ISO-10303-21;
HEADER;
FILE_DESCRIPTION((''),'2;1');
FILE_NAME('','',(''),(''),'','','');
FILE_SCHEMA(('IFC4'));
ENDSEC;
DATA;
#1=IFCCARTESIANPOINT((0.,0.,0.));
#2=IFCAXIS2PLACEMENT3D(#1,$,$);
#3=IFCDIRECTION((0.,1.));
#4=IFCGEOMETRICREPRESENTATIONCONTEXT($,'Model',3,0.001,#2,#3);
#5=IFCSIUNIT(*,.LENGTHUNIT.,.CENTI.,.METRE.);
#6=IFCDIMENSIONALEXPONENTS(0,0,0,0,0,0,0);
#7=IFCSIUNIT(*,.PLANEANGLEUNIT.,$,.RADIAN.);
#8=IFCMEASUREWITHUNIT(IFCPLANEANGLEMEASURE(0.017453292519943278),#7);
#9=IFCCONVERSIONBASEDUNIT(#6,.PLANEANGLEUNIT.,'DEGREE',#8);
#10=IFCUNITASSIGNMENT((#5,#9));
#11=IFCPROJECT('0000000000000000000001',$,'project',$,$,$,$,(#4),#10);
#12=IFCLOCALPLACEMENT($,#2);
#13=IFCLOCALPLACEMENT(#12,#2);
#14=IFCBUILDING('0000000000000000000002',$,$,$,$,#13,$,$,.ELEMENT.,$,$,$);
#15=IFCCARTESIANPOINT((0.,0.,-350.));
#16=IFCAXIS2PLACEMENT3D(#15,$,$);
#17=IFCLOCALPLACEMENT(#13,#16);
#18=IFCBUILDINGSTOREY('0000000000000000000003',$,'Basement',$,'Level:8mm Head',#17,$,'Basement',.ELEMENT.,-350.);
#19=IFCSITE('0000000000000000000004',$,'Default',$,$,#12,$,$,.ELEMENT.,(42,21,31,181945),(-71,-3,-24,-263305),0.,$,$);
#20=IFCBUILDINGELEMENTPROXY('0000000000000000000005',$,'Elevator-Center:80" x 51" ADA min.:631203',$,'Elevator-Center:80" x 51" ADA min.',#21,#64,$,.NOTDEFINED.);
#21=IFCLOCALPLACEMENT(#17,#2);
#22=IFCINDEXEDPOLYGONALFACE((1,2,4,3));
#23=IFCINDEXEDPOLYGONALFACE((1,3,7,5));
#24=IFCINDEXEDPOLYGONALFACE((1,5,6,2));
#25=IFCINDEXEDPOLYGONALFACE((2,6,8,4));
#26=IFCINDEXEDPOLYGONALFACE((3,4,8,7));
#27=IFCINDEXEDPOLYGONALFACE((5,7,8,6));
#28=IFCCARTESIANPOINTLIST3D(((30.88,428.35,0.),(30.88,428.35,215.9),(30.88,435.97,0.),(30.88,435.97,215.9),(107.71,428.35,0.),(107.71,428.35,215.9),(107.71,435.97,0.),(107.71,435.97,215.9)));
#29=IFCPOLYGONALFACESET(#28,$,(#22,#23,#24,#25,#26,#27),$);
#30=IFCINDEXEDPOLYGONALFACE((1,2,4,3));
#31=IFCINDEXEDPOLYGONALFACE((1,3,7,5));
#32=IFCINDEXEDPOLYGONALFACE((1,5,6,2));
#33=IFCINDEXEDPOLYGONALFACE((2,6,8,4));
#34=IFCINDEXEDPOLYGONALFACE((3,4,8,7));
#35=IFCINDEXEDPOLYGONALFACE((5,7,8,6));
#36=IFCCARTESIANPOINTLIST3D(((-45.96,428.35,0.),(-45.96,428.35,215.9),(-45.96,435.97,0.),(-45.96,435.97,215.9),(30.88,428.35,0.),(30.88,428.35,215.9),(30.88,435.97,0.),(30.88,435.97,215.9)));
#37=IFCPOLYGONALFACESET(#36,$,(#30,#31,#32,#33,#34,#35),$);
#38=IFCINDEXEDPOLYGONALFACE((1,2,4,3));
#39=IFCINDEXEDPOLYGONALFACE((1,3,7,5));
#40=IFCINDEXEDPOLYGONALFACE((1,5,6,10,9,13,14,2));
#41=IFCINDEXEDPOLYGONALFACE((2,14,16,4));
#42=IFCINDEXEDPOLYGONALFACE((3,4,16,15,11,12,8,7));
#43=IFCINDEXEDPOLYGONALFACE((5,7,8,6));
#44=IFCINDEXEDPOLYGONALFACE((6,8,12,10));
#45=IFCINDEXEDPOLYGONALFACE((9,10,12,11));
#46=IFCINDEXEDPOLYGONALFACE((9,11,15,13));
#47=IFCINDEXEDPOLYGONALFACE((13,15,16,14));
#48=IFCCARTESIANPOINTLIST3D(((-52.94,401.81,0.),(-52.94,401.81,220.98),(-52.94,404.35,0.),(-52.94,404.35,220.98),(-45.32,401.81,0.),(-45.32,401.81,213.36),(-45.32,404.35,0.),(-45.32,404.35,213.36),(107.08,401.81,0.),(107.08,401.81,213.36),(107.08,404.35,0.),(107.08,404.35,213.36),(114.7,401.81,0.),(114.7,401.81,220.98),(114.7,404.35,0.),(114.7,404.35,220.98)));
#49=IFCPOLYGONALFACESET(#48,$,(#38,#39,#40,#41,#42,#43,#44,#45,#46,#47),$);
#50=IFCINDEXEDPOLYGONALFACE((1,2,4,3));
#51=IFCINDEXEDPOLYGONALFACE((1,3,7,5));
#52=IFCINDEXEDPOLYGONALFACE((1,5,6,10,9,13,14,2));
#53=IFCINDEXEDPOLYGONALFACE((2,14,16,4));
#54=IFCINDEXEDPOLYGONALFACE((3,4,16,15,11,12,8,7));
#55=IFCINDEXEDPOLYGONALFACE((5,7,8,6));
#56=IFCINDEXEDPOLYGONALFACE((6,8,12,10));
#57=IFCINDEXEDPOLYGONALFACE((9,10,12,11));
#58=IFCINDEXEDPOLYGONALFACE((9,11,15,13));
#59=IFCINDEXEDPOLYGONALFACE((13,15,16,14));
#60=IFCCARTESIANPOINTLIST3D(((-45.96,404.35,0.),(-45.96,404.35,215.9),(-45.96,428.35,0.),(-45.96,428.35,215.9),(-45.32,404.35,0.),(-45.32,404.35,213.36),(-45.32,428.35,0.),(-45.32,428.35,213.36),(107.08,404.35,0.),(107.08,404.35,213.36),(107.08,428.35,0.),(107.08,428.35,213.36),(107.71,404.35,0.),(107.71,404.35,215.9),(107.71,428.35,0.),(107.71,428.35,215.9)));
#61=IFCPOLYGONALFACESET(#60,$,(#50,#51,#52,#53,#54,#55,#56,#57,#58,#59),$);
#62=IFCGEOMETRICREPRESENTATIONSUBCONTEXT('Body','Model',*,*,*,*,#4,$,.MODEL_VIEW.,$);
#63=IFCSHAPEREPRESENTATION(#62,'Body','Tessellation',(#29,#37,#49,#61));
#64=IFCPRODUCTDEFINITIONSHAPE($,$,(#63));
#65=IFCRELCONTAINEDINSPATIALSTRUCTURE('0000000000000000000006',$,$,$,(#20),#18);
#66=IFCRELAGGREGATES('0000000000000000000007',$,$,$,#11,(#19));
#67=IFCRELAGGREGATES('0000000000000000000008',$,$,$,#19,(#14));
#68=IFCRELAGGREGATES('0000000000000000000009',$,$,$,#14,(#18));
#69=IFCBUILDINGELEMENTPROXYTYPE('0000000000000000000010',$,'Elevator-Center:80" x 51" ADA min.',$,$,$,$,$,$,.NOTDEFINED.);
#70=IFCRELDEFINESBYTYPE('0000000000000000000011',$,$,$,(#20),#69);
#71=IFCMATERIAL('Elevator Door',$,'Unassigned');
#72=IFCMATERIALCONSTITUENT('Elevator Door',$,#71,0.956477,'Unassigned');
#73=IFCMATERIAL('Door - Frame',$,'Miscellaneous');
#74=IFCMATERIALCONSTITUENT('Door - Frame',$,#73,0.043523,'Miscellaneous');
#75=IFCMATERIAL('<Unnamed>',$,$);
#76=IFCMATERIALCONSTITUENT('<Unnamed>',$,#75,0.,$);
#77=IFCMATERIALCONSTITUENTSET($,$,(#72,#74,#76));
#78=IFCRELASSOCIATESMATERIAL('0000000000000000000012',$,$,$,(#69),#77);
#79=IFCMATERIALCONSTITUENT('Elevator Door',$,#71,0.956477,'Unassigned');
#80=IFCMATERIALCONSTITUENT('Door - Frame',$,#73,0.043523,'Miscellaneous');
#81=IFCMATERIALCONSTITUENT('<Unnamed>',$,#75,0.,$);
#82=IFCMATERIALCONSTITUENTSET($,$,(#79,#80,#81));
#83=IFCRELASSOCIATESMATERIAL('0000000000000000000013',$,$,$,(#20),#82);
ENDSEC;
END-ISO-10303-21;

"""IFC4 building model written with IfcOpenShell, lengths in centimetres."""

from ifc_helpers import new_model, entity, si_unit, converted_unit, direction, frame, origin, place, context, subcontext, project, spatial, indexed_curve, outline, extrude, source, transform, mapped, material, constituent, constituent_set, type_object, type_shapes, element, save


model = new_model("IFC4")

# Units and contexts
model_context = context("Model", 3, precision=0.001, world=origin(), true_north=direction((0.0, 1.0)))
body_context = subcontext(model_context, "Body", "Model", "MODEL_VIEW")
ifc_project = project(units=[si_unit("LENGTHUNIT", "METRE", prefix="CENTI"), converted_unit("PLANEANGLEUNIT", "DEGREE", entity("IfcPlaneAngleMeasure", 0.017453292519943278), si_unit("PLANEANGLEUNIT", "RADIAN"), dimensions=[0, 0, 0, 0, 0, 0, 0])], contexts=[model_context])

# Site, building, storey
site_placement = place(None, origin())
site = spatial("IfcSite", under=ifc_project, at=site_placement, Name="Default", CompositionType="ELEMENT", RefLatitude=(42, 21, 31, 181945), RefLongitude=(-71, -3, -24, -263305), RefElevation=0.0)
building_placement = place(site_placement, origin())
building = spatial("IfcBuilding", under=site, at=building_placement, CompositionType="ELEMENT")
storey_placement = place(building_placement, frame((0.0, 0.0, -350.0)))
storey = spatial("IfcBuildingStorey", under=building, at=storey_placement, Name="Basement", ObjectType="Level:8mm Head", LongName="Basement", CompositionType="ELEMENT", Elevation=-350.0)

# Shared definitions
ifc_material_1 = material(Name="Door - Frame", Category="Miscellaneous")

# Building element proxy
ifc_material_2 = material(Name="Elevator Door", Category="Unassigned")
ifc_constituent_1 = constituent(ifc_material_2, Name="Elevator Door", Category="Unassigned", fraction=0.956477)
ifc_constituent_2 = constituent(ifc_material_1, Name="Door - Frame", Category="Miscellaneous", fraction=0.043523)
ifc_material_3 = material(Name="<Unnamed>")
ifc_constituent_3 = constituent(ifc_material_3, Name="<Unnamed>", fraction=0.0)
ifc_constituent_set_1 = constituent_set(constituents=[ifc_constituent_1, ifc_constituent_2, ifc_constituent_3])
ifc_constituent_4 = constituent(ifc_material_2, Name="Elevator Door", Category="Unassigned", fraction=0.956477)
ifc_constituent_5 = constituent(ifc_material_1, Name="Door - Frame", Category="Miscellaneous", fraction=0.043523)
ifc_constituent_6 = constituent(ifc_material_3, Name="<Unnamed>", fraction=0.0)
ifc_constituent_set_2 = constituent_set(constituents=[ifc_constituent_4, ifc_constituent_5, ifc_constituent_6])
building_element_proxy_type = type_object("IfcBuildingElementProxyType", Name="Elevator-Center:80\" x 51\" ADA min.", PredefinedType="NOTDEFINED", material=ifc_constituent_set_2)
shared_shape_1 = source(origin(), body_context, "Body", "SweptSolid", [
    extrude(outline(indexed_curve([(-3.81, -38.42), (3.81, -38.42), (3.81, 38.42), (-3.81, 38.42), (-3.81, -38.42)], self_intersect=False)), frame((28.5, 15.81, 0.0), z_axis=(0.0, 0.0, 1.0), x_axis=(0.0, 1.0, 0.0)), (0.0, 0.0, 1.0), 215.9),
    extrude(outline(indexed_curve([(-3.81, -38.42), (3.81, -38.42), (3.81, 38.42), (-3.81, 38.42), (-3.81, -38.42)], self_intersect=False)), frame((-48.33, 15.81, 0.0), z_axis=(0.0, 0.0, 1.0), x_axis=(0.0, 1.0, 0.0)), (0.0, 0.0, 1.0), 215.9),
    extrude(outline(indexed_curve([(-108.58, -83.82), (112.39, -83.82), (112.39, 83.82), (-108.58, 83.82), (-108.58, 76.2), (104.78, 76.2), (104.78, -76.2), (-108.58, -76.2), (-108.58, -83.82)], self_intersect=False)), frame((-9.91, -14.54, 108.58), z_axis=(0.0, 1.0, 0.0), x_axis=(0.0, 0.0, 1.0)), (0.0, 0.0, 1.0), 2.54),
    extrude(outline(indexed_curve([(-107.31, -76.84), (108.58, -76.84), (108.58, 76.83), (-107.31, 76.83), (-107.31, 76.2), (106.04, 76.2), (106.04, -76.2), (-107.31, -76.2), (-107.31, -76.84)], self_intersect=False)), frame((-9.91, -12.0, 107.31), z_axis=(0.0, 1.0, 0.0), x_axis=(0.0, 0.0, 1.0)), (0.0, 0.0, 1.0), 24.0),
])
type_shapes(building_element_proxy_type, [shared_shape_1])
proxy_placement = place(storey_placement, frame((40.79, 416.35, 0.0)))
element("IfcBuildingElementProxy", 1, at=proxy_placement, inside=storey, type_object=building_element_proxy_type, material=ifc_constituent_set_1, Name="Elevator-Center:80\" x 51\" ADA min.:631203", ObjectType="Elevator-Center:80\" x 51\" ADA min.", PredefinedType="NOTDEFINED", context=body_context, shape_type="MappedRepresentation", body=[
    mapped(shared_shape_1, transform((0.0, 0.0, 0.0), scale=1.0)),
])

save(model, "model.ifc")
